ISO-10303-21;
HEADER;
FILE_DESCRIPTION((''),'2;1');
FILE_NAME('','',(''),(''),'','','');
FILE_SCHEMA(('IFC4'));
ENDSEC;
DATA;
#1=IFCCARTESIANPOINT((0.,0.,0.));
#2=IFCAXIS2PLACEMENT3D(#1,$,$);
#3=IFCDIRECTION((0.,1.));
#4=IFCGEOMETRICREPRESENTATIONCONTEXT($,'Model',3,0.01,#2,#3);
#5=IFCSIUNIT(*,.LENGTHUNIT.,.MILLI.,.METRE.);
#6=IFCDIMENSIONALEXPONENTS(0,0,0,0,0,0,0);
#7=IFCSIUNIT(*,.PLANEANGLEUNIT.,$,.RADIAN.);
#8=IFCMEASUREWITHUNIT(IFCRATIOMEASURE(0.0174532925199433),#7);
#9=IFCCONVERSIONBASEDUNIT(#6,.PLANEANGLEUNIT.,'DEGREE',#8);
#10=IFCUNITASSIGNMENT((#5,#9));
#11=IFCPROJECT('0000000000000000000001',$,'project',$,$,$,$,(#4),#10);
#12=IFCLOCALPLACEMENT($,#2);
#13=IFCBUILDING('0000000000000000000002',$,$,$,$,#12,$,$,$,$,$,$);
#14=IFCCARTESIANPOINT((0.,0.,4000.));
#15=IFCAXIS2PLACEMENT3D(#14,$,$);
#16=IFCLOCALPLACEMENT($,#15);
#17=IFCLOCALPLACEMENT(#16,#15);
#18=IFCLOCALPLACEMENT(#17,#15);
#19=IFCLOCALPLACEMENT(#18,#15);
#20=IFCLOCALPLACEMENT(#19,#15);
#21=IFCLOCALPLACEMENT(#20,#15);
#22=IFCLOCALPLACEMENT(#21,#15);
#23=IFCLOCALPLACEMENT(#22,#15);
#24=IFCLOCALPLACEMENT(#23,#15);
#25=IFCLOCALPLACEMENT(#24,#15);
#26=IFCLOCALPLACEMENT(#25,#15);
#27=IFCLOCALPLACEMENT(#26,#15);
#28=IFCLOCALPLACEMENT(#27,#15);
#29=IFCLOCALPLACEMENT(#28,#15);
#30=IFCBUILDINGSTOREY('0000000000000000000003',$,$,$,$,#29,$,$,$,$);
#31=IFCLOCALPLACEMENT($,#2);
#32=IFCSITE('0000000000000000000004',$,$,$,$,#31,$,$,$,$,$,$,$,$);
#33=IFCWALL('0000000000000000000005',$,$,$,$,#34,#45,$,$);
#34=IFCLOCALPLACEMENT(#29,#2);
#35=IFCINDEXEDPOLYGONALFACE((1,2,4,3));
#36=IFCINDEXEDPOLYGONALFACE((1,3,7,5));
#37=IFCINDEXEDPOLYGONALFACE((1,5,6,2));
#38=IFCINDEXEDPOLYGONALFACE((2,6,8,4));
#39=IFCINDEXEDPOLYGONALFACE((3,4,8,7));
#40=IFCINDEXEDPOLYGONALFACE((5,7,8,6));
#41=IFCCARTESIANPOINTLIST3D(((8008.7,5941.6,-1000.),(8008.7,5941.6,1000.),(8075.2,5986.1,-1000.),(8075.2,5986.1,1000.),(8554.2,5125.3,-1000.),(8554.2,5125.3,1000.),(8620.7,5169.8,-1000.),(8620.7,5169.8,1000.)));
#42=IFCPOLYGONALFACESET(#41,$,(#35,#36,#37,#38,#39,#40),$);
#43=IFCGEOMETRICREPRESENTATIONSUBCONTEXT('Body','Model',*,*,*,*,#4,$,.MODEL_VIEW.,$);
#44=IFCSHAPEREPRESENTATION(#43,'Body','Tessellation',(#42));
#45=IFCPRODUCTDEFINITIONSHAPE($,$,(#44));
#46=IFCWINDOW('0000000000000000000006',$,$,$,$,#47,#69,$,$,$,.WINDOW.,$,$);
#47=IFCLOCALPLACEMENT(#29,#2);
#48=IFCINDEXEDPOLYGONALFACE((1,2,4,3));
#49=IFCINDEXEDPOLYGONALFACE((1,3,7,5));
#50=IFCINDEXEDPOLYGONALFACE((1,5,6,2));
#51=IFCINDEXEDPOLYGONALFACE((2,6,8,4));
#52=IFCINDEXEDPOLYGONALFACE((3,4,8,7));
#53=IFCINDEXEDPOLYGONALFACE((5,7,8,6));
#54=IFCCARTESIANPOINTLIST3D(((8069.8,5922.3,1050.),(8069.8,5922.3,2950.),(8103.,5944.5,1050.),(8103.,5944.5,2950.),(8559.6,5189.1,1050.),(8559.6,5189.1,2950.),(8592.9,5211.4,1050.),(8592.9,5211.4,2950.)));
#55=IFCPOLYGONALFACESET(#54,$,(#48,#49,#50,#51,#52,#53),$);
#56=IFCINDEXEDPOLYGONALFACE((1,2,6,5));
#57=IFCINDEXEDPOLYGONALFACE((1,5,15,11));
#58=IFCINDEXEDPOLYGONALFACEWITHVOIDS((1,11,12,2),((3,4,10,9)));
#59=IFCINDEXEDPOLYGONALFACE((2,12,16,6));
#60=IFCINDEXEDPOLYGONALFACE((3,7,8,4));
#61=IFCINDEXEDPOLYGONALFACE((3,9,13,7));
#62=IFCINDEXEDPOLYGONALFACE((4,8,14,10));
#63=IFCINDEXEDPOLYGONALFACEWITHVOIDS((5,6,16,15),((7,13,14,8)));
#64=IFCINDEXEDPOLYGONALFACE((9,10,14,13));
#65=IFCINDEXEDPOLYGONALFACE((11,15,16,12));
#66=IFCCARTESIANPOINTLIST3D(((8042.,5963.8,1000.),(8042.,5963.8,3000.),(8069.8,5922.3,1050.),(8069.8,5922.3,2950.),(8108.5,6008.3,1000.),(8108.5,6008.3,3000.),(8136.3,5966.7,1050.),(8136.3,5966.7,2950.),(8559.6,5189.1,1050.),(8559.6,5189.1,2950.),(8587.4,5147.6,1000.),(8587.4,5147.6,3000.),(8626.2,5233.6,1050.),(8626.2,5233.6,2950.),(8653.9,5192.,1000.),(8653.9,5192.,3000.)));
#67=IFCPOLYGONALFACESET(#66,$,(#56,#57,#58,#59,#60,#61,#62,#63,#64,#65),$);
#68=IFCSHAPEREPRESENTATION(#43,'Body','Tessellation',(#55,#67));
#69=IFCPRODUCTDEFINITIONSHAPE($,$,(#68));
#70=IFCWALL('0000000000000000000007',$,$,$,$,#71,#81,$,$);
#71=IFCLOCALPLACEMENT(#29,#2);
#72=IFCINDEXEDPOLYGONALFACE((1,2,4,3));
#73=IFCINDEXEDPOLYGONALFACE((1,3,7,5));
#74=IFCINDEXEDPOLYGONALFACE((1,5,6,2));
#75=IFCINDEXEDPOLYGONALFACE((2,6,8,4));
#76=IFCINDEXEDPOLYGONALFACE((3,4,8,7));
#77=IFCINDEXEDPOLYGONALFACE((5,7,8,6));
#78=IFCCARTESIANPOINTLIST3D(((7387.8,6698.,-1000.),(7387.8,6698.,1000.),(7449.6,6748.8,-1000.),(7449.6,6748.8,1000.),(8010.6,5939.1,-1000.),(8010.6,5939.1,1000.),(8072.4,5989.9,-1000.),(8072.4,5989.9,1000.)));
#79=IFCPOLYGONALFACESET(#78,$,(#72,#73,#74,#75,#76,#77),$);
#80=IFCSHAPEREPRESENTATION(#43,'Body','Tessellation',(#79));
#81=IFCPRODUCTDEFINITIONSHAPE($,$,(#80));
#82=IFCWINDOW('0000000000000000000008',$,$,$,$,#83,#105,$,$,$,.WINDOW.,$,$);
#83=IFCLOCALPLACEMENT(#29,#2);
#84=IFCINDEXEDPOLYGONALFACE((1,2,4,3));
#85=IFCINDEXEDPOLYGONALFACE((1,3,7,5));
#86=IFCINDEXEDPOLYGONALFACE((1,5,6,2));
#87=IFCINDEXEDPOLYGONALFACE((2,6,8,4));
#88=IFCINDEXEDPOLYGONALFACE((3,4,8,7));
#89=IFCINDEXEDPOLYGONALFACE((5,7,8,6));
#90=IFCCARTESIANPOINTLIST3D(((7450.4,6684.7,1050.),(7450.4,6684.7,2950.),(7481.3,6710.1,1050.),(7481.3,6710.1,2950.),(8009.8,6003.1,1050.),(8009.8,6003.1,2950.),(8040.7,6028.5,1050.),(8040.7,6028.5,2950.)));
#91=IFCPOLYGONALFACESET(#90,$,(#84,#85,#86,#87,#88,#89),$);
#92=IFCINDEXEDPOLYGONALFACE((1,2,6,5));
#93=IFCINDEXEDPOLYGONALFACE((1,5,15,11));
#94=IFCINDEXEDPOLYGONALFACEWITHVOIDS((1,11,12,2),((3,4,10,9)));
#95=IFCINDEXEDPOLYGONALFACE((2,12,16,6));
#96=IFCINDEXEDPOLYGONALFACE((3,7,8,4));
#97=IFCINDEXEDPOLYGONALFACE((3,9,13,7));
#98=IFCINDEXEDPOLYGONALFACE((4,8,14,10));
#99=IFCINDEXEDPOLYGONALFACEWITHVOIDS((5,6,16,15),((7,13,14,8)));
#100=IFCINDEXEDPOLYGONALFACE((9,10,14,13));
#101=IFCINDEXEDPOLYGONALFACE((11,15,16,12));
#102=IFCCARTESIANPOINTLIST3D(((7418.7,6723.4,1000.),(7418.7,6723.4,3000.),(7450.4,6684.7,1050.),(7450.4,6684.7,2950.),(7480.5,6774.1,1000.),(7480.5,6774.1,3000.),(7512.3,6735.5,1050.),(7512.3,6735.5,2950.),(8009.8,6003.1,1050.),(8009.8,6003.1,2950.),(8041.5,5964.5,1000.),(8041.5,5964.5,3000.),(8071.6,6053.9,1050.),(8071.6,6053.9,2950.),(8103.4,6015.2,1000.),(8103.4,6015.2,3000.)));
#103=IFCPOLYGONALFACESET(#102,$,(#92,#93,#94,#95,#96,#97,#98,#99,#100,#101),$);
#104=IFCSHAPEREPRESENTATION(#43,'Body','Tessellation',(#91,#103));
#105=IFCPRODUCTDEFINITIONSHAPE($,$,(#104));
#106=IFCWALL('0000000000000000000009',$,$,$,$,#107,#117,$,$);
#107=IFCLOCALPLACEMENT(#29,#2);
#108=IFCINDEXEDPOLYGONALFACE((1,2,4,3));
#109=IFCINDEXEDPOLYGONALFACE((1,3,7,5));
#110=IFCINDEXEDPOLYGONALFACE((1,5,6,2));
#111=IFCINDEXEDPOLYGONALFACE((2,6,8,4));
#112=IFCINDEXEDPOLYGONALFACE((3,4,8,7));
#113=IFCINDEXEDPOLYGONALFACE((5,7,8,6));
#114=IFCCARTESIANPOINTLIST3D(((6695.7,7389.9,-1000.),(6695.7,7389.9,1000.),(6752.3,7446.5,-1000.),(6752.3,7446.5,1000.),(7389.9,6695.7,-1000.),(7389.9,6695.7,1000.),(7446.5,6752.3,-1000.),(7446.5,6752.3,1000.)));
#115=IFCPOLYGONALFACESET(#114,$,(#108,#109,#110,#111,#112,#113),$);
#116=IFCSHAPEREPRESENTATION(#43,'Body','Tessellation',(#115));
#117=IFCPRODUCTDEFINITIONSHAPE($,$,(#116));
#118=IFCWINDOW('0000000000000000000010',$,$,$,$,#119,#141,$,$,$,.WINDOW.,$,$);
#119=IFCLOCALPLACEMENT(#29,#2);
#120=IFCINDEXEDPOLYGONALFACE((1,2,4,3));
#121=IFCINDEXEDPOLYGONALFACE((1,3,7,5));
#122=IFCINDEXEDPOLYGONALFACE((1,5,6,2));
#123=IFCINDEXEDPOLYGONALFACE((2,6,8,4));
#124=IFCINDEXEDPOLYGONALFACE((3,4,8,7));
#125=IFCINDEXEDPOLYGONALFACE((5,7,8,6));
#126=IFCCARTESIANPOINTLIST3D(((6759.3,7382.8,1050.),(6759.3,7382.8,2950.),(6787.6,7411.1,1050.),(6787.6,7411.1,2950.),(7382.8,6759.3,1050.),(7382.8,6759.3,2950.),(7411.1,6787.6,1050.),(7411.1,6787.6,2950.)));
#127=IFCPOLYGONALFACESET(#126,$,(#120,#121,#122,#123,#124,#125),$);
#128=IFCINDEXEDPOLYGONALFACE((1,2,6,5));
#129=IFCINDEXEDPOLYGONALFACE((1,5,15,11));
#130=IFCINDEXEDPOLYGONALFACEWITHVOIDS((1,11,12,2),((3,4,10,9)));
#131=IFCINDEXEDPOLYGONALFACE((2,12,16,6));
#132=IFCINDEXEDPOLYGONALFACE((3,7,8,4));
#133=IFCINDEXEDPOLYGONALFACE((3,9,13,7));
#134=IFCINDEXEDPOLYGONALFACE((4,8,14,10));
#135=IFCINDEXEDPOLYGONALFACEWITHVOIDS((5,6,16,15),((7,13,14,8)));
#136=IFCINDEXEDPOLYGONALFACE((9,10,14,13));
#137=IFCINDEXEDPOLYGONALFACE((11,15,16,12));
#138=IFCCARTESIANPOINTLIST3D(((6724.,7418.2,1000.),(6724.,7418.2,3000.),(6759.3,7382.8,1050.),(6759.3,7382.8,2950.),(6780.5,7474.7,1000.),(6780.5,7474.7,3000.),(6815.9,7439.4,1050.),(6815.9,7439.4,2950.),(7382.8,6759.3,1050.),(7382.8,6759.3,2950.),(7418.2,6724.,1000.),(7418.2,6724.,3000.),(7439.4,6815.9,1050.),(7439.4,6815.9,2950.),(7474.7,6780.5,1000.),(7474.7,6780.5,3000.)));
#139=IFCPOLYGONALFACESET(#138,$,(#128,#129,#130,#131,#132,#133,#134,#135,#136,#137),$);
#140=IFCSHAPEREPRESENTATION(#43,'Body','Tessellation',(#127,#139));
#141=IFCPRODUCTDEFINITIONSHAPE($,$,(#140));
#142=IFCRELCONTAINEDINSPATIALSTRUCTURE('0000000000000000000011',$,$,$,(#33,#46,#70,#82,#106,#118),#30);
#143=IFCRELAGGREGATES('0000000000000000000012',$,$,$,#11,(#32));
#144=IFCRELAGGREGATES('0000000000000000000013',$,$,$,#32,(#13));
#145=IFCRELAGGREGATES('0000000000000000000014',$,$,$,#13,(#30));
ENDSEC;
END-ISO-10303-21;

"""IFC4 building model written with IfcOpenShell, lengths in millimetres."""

from ifc_helpers import new_model, entity, si_unit, converted_unit, direction, frame, origin, origin_2d, place, context, subcontext, project, spatial, rectangle, extrude, element, save


model = new_model("IFC4")

# Units and contexts
model_context = context("Model", 3, precision=0.01, world=origin(), true_north=direction((0.0, 1.0)))
body_context = subcontext(model_context, "Body", "Model", "MODEL_VIEW")
ifc_project = project(units=[si_unit("LENGTHUNIT", "METRE", prefix="MILLI"), converted_unit("PLANEANGLEUNIT", "DEGREE", entity("IfcRatioMeasure", 0.0174532925199433), si_unit("PLANEANGLEUNIT", "RADIAN"), dimensions=[0, 0, 0, 0, 0, 0, 0])], contexts=[model_context])

# Site, building, storey
site_placement = place(None, origin())
site = spatial("IfcSite", under=ifc_project, at=site_placement)
building_placement = place(None, origin())
building = spatial("IfcBuilding", under=site, at=building_placement)
placement_1 = place(None, frame((0.0, 0.0, 4000.0)))
placement_2 = place(placement_1, frame((0.0, 0.0, 4000.0)))
placement_3 = place(placement_2, frame((0.0, 0.0, 4000.0)))
placement_4 = place(placement_3, frame((0.0, 0.0, 4000.0)))
placement_5 = place(placement_4, frame((0.0, 0.0, 4000.0)))
placement_6 = place(placement_5, frame((0.0, 0.0, 4000.0)))
placement_7 = place(placement_6, frame((0.0, 0.0, 4000.0)))
placement_8 = place(placement_7, frame((0.0, 0.0, 4000.0)))
placement_9 = place(placement_8, frame((0.0, 0.0, 4000.0)))
placement_10 = place(placement_9, frame((0.0, 0.0, 4000.0)))
placement_11 = place(placement_10, frame((0.0, 0.0, 4000.0)))
placement_12 = place(placement_11, frame((0.0, 0.0, 4000.0)))
placement_13 = place(placement_12, frame((0.0, 0.0, 4000.0)))
storey_placement = place(placement_13, frame((0.0, 0.0, 4000.0)))
storey = spatial("IfcBuildingStorey", under=building, at=storey_placement)

# Shared definitions
cartesian_point_1 = entity("IfcCartesianPoint", [-440.9, -950.0])
shared_polyline = entity("IfcPolyline", [cartesian_point_1, entity("IfcCartesianPoint", [-440.9, 950.0]), entity("IfcCartesianPoint", [-440.9, 950.0]), entity("IfcCartesianPoint", [440.9, 950.0]), entity("IfcCartesianPoint", [440.9, 950.0]), entity("IfcCartesianPoint", [440.9, -950.0]), entity("IfcCartesianPoint", [440.9, -950.0]), entity("IfcCartesianPoint", [-440.9, -950.0]), cartesian_point_1])

# Wall
wall_1_placement = place(storey_placement, frame((8314.7, 5555.7, -1000.0), z_axis=(0.0, 0.0, 1.0), x_axis=(-5555.702343, 8314.696115, 0.0)))
element("IfcWall", 1, at=wall_1_placement, inside=storey, context=body_context, shape_type="SweptSolid", body=[
    extrude(rectangle(XDim=981.7, YDim=80.0, at=origin_2d()), origin(), (0.0, 0.0, 1.0), 2000.0),
])

# Window
window_1_placement = place(storey_placement, frame((8314.7, 5555.7, 2000.0), z_axis=(0.0, 0.0, 1.0), x_axis=(-5555.702343, 8314.696115, 0.0)))
cartesian_point_2 = entity("IfcCartesianPoint", [-490.9, -1000.0])
element("IfcWindow", 2, at=window_1_placement, inside=storey, PredefinedType="WINDOW", context=body_context, shape_type="SweptSolid", body=[
    entity("IfcExtrudedAreaSolid", entity("IfcArbitraryClosedProfileDef", "AREA", None, shared_polyline), entity("IfcAxis2Placement3D", entity("IfcCartesianPoint", [0.0, 0.0, 0.0]), entity("IfcDirection", [0.0, -1.0, 0.0]), entity("IfcDirection", [1.0, 0.0, 0.0])), entity("IfcDirection", [0.0, 0.0, 1.0]), 40.0),
    entity("IfcExtrudedAreaSolid", entity("IfcArbitraryProfileDefWithVoids", "AREA", None, entity("IfcPolyline", [cartesian_point_2, entity("IfcCartesianPoint", [-490.9, 1000.0]), entity("IfcCartesianPoint", [-490.9, 1000.0]), entity("IfcCartesianPoint", [490.9, 1000.0]), entity("IfcCartesianPoint", [490.9, 1000.0]), entity("IfcCartesianPoint", [490.9, -1000.0]), entity("IfcCartesianPoint", [490.9, -1000.0]), entity("IfcCartesianPoint", [-490.9, -1000.0]), cartesian_point_2]), [shared_polyline]), entity("IfcAxis2Placement3D", entity("IfcCartesianPoint", [0.0, 0.0, 0.0]), entity("IfcDirection", [0.0, -1.0, 0.0]), entity("IfcDirection", [1.0, 0.0, 0.0])), entity("IfcDirection", [0.0, 0.0, 1.0]), 80.0),
])

# Wall
wall_2_placement = place(storey_placement, frame((7730.1, 6343.9, -1000.0), z_axis=(0.0, 0.0, 1.0), x_axis=(-6343.932701, 7730.104649, 0.0)))
element("IfcWall", 3, at=wall_2_placement, inside=storey, context=body_context, shape_type="SweptSolid", body=[
    extrude(rectangle(XDim=981.7, YDim=80.0, at=origin_2d()), origin(), (0.0, 0.0, 1.0), 2000.0),
])

# Window
window_2_placement = place(storey_placement, frame((7730.1, 6343.9, 2000.0), z_axis=(0.0, 0.0, 1.0), x_axis=(-6343.932701, 7730.104649, 0.0)))
cartesian_point_3 = entity("IfcCartesianPoint", [-490.9, -1000.0])
element("IfcWindow", 4, at=window_2_placement, inside=storey, PredefinedType="WINDOW", context=body_context, shape_type="SweptSolid", body=[
    entity("IfcExtrudedAreaSolid", entity("IfcArbitraryClosedProfileDef", "AREA", None, shared_polyline), entity("IfcAxis2Placement3D", entity("IfcCartesianPoint", [0.0, 0.0, 0.0]), entity("IfcDirection", [0.0, -1.0, 0.0]), entity("IfcDirection", [1.0, 0.0, 0.0])), entity("IfcDirection", [0.0, 0.0, 1.0]), 40.0),
    entity("IfcExtrudedAreaSolid", entity("IfcArbitraryProfileDefWithVoids", "AREA", None, entity("IfcPolyline", [cartesian_point_3, entity("IfcCartesianPoint", [-490.9, 1000.0]), entity("IfcCartesianPoint", [-490.9, 1000.0]), entity("IfcCartesianPoint", [490.9, 1000.0]), entity("IfcCartesianPoint", [490.9, 1000.0]), entity("IfcCartesianPoint", [490.9, -1000.0]), entity("IfcCartesianPoint", [490.9, -1000.0]), entity("IfcCartesianPoint", [-490.9, -1000.0]), cartesian_point_3]), [shared_polyline]), entity("IfcAxis2Placement3D", entity("IfcCartesianPoint", [0.0, 0.0, 0.0]), entity("IfcDirection", [0.0, -1.0, 0.0]), entity("IfcDirection", [1.0, 0.0, 0.0])), entity("IfcDirection", [0.0, 0.0, 1.0]), 80.0),
])

# Wall
wall_3_placement = place(storey_placement, frame((7071.1, 7071.1, -1000.0), z_axis=(0.0, 0.0, 1.0), x_axis=(-7071.067966, 7071.067657, 0.0)))
element("IfcWall", 5, at=wall_3_placement, inside=storey, context=body_context, shape_type="SweptSolid", body=[
    extrude(rectangle(XDim=981.7, YDim=80.0, at=origin_2d()), origin(), (0.0, 0.0, 1.0), 2000.0),
])

# Window
window_3_placement = place(storey_placement, frame((7071.1, 7071.1, 2000.0), z_axis=(0.0, 0.0, 1.0), x_axis=(-7071.067966, 7071.067657, 0.0)))
cartesian_point_4 = entity("IfcCartesianPoint", [-490.9, -1000.0])
element("IfcWindow", 6, at=window_3_placement, inside=storey, PredefinedType="WINDOW", context=body_context, shape_type="SweptSolid", body=[
    entity("IfcExtrudedAreaSolid", entity("IfcArbitraryClosedProfileDef", "AREA", None, shared_polyline), entity("IfcAxis2Placement3D", entity("IfcCartesianPoint", [0.0, 0.0, 0.0]), entity("IfcDirection", [0.0, -1.0, 0.0]), entity("IfcDirection", [1.0, 0.0, 0.0])), entity("IfcDirection", [0.0, 0.0, 1.0]), 40.0),
    entity("IfcExtrudedAreaSolid", entity("IfcArbitraryProfileDefWithVoids", "AREA", None, entity("IfcPolyline", [cartesian_point_4, entity("IfcCartesianPoint", [-490.9, 1000.0]), entity("IfcCartesianPoint", [-490.9, 1000.0]), entity("IfcCartesianPoint", [490.9, 1000.0]), entity("IfcCartesianPoint", [490.9, 1000.0]), entity("IfcCartesianPoint", [490.9, -1000.0]), entity("IfcCartesianPoint", [490.9, -1000.0]), entity("IfcCartesianPoint", [-490.9, -1000.0]), cartesian_point_4]), [shared_polyline]), entity("IfcAxis2Placement3D", entity("IfcCartesianPoint", [0.0, 0.0, 0.0]), entity("IfcDirection", [0.0, -1.0, 0.0]), entity("IfcDirection", [1.0, 0.0, 0.0])), entity("IfcDirection", [0.0, 0.0, 1.0]), 80.0),
])

save(model, "model.ifc")
